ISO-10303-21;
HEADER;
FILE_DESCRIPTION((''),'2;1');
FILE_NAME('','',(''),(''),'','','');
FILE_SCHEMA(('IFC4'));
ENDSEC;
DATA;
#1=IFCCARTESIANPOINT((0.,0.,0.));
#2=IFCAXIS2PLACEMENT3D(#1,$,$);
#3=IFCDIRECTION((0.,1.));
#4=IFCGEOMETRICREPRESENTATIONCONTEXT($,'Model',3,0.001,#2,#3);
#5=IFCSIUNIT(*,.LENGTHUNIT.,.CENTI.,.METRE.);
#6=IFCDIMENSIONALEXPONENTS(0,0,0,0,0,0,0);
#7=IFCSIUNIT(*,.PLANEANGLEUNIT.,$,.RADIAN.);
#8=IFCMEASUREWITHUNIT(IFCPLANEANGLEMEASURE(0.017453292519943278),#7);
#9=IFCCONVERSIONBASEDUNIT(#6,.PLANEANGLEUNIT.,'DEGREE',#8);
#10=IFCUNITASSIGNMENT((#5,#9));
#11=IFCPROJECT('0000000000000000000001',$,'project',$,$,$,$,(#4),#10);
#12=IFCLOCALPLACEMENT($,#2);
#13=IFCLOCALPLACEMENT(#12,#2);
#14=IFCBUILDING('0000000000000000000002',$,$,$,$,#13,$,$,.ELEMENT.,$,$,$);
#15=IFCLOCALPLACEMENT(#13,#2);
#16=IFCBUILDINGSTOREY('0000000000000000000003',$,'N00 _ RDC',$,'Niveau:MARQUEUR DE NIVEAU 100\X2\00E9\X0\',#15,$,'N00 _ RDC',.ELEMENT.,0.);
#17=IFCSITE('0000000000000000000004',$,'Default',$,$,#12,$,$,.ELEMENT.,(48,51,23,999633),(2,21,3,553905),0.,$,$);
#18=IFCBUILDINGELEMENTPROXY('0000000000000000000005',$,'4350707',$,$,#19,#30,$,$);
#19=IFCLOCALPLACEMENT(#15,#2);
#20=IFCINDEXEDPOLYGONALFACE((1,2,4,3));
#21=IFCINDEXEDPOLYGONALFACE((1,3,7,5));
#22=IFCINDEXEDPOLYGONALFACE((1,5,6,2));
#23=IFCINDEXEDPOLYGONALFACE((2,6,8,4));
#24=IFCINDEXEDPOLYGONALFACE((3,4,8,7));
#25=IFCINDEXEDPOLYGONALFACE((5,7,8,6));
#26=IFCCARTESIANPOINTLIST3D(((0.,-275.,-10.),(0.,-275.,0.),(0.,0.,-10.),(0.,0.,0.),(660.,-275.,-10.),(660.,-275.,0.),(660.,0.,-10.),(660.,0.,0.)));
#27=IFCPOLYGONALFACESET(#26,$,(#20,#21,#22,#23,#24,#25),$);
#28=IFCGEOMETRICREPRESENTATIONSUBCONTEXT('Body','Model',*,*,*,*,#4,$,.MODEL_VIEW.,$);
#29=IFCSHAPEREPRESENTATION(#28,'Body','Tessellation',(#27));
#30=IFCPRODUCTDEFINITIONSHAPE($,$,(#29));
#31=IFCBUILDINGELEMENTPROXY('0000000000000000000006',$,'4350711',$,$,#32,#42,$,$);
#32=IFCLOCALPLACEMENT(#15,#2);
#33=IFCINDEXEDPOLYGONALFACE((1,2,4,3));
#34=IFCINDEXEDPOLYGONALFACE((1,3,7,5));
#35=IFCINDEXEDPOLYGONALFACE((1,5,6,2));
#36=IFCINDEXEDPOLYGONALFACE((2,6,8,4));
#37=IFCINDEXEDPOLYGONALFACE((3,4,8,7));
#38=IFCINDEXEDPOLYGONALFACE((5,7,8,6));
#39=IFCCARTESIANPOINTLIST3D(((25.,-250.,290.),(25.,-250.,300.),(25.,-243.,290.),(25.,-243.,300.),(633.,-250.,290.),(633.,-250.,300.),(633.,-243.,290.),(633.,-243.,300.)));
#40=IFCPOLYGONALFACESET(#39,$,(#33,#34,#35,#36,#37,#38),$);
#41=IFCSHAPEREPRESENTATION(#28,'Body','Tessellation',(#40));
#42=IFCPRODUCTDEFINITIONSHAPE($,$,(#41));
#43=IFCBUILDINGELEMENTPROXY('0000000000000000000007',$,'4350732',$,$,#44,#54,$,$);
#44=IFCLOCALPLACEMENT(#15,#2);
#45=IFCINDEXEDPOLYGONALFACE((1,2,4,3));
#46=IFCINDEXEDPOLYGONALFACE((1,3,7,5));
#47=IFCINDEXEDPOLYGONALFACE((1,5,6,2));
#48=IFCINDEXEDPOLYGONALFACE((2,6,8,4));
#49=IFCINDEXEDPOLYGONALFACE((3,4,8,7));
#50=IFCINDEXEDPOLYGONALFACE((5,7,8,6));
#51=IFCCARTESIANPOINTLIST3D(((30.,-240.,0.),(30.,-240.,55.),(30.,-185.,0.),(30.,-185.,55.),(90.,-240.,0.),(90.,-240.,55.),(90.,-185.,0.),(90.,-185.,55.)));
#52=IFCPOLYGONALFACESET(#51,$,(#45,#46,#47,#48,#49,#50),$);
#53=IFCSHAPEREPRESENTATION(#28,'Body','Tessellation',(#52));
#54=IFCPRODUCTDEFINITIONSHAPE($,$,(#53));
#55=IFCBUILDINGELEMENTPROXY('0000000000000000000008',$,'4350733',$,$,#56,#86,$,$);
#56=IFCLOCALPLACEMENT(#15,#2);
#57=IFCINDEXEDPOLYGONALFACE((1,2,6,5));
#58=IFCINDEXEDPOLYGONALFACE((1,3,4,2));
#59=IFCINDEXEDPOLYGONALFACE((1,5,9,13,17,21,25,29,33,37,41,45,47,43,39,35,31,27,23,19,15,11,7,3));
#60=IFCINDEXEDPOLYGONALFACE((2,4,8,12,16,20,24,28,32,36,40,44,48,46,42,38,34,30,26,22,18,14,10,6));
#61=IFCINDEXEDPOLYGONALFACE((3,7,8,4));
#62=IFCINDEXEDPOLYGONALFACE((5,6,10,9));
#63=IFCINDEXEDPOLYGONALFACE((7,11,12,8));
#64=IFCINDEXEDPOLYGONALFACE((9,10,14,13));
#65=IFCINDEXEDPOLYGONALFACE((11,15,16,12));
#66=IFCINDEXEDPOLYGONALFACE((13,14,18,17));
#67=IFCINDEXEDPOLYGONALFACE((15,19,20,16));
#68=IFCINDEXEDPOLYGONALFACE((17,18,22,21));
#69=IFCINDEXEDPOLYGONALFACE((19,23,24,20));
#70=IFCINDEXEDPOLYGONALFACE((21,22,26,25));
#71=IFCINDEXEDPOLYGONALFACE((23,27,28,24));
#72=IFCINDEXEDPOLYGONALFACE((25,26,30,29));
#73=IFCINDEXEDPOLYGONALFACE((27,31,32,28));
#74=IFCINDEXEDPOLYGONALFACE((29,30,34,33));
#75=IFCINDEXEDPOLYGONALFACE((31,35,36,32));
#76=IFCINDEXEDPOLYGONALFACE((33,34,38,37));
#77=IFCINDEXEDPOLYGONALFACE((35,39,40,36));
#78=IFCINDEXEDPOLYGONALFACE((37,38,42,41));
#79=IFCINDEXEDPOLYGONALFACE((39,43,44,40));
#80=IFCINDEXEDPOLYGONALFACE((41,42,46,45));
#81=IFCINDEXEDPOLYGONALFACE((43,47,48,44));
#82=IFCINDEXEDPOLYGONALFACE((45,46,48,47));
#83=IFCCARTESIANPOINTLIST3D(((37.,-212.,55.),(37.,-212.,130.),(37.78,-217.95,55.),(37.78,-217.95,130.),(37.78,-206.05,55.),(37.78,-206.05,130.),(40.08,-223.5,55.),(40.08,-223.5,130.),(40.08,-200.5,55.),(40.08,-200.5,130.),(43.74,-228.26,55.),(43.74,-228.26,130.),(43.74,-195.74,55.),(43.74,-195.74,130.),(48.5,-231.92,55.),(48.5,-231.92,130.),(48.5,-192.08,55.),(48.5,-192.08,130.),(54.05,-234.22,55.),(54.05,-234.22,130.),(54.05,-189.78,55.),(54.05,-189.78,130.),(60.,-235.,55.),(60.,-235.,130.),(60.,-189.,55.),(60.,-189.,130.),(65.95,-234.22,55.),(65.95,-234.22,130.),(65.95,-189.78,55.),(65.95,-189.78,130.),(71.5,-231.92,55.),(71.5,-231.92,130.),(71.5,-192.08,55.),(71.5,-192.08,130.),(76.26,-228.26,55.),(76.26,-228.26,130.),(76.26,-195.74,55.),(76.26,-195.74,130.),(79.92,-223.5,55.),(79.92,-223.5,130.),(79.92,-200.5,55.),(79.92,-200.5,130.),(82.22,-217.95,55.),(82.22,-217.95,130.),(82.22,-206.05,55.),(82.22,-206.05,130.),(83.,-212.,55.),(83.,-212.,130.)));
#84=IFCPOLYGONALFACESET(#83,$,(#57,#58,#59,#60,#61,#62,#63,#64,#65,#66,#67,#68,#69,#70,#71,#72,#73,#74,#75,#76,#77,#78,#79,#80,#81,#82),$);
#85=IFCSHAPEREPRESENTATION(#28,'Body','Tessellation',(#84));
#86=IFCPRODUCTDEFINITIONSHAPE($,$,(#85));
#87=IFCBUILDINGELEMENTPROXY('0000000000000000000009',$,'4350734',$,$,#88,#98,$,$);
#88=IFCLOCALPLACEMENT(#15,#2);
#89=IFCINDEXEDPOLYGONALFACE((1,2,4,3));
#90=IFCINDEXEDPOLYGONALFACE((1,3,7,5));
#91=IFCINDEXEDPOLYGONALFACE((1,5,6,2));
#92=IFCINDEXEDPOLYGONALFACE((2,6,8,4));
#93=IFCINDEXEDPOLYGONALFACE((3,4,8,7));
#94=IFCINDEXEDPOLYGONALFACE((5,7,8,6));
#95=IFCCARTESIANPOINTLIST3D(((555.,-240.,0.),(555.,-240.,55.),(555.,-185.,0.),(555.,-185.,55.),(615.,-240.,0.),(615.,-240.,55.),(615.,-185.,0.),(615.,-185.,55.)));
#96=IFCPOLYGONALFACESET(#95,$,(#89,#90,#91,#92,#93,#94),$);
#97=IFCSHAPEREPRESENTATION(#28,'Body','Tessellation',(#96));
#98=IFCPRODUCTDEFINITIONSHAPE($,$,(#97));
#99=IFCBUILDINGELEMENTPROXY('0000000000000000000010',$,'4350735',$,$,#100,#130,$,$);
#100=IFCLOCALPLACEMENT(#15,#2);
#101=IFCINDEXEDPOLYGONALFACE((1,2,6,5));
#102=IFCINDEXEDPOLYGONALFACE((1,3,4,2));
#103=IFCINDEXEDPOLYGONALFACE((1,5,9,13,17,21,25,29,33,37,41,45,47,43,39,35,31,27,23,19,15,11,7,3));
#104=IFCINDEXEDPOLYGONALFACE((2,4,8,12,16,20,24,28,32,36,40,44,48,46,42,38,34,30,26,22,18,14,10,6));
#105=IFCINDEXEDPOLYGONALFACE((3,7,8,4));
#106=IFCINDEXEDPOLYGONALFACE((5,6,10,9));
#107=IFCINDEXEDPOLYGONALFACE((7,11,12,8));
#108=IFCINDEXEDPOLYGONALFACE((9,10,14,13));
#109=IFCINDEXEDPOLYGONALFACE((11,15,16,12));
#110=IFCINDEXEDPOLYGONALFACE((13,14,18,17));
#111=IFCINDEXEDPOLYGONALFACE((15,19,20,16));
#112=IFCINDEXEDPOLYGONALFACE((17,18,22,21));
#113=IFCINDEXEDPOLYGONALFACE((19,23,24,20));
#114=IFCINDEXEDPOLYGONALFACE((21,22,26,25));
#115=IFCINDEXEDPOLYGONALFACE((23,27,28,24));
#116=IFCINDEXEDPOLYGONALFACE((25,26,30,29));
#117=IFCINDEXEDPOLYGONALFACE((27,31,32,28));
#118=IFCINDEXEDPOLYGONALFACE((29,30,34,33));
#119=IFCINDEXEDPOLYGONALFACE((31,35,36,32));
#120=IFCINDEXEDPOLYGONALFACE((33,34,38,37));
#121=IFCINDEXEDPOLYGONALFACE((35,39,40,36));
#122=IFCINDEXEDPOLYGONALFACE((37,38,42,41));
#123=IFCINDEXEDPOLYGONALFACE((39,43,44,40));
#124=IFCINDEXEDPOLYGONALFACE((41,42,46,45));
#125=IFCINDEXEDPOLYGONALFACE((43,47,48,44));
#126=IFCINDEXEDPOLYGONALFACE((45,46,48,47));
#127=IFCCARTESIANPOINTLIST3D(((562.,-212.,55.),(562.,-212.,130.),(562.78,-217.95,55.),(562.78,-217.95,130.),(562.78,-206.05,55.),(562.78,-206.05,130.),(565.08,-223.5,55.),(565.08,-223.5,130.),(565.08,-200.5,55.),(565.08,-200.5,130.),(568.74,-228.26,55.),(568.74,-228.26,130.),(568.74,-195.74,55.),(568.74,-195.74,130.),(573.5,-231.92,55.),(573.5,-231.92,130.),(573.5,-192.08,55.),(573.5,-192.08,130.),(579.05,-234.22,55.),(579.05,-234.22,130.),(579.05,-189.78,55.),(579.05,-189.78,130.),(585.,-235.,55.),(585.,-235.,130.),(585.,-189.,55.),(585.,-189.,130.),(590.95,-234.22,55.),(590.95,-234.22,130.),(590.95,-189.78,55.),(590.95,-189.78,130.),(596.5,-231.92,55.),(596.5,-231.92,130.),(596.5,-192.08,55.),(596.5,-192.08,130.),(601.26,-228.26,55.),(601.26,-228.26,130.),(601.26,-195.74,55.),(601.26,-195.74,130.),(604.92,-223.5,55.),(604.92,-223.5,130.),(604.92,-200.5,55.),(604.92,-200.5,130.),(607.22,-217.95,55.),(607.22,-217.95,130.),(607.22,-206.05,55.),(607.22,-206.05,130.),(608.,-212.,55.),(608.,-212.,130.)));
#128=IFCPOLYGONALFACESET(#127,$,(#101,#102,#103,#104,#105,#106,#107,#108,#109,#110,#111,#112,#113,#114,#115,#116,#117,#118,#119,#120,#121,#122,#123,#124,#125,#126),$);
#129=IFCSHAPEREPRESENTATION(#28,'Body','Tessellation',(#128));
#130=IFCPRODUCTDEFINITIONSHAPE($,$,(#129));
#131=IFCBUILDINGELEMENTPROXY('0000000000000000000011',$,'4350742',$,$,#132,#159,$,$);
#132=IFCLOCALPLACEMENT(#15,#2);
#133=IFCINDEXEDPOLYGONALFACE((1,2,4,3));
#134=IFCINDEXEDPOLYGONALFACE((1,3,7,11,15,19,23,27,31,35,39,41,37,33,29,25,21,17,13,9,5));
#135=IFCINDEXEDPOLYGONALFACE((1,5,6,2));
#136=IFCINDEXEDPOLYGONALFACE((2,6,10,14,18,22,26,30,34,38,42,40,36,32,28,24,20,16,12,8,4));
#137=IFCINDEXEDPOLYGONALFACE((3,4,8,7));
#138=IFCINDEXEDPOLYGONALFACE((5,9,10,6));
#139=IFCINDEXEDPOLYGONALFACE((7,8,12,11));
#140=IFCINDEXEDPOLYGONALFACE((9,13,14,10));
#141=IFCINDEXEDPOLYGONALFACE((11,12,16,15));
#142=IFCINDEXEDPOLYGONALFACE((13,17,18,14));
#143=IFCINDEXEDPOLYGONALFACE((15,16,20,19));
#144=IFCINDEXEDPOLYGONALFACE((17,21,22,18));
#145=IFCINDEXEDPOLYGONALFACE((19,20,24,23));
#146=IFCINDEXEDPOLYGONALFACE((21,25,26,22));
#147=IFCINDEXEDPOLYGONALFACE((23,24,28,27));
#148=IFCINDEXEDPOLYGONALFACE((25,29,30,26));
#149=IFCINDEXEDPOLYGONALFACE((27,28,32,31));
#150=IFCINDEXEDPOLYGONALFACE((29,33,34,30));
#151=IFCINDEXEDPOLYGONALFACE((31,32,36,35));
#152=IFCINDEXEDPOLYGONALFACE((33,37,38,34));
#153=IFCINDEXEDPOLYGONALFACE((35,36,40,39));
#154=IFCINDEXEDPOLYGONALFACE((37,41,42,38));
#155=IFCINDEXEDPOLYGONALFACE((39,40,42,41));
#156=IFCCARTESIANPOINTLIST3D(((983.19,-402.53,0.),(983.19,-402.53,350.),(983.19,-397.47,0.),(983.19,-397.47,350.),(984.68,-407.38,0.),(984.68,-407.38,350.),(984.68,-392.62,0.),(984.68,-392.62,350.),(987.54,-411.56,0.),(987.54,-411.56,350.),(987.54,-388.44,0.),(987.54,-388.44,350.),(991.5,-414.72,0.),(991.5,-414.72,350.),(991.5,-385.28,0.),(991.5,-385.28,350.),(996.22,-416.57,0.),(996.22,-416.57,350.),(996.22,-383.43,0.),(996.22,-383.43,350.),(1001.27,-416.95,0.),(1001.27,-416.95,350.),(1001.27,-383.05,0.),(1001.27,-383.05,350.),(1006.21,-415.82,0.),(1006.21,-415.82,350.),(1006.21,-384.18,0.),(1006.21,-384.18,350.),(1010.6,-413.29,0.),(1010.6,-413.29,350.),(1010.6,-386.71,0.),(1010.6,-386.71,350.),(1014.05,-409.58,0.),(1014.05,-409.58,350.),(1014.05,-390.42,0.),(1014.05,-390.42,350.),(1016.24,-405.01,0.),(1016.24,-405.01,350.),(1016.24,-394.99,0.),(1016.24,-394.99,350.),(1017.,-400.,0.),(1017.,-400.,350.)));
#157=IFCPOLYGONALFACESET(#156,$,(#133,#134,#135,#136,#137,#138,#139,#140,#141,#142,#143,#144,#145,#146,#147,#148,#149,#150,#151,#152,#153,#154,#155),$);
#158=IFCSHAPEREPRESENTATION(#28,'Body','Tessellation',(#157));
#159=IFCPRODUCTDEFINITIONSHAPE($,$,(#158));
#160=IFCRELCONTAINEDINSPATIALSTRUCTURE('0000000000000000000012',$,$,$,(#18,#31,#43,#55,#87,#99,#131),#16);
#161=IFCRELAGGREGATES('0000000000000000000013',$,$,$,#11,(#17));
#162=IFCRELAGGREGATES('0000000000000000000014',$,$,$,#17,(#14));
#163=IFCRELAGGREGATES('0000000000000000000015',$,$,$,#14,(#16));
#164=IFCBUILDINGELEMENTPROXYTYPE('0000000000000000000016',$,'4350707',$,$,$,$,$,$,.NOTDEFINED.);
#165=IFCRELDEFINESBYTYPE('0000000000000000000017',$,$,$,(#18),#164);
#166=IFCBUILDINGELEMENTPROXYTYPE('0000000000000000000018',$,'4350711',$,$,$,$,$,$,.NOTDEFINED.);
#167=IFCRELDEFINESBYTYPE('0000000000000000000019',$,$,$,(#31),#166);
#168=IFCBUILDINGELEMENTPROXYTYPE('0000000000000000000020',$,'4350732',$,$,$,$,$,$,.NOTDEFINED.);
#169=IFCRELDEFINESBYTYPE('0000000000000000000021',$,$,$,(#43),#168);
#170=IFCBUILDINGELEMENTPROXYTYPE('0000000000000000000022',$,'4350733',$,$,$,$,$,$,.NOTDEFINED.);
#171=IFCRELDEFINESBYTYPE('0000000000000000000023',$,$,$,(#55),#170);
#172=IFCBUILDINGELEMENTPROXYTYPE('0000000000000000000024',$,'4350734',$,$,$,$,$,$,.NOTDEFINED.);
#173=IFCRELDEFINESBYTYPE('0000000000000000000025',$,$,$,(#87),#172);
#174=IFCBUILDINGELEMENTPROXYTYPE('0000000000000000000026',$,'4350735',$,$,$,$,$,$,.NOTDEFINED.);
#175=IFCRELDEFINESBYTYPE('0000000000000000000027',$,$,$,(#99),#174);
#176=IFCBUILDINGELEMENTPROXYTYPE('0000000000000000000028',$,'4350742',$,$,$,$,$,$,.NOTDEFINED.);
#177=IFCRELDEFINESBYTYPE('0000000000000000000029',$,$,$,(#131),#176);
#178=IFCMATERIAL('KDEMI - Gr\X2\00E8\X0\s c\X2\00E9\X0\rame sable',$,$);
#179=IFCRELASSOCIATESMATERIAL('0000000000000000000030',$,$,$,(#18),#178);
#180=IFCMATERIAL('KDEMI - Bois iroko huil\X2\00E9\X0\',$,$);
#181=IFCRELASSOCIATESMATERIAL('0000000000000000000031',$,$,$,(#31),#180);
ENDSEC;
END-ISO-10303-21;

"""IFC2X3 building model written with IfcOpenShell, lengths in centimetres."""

from ifc_helpers import new_model, entity, si_unit, converted_unit, direction, frame, frame_2d, origin, origin_2d_with_axis, place, context, subcontext, project, spatial, rectangle, circle, extrude, material, type_object, element, save


model = new_model("IFC2X3")

# Units and contexts
model_context = context("Model", 3, precision=0.001, world=origin(), true_north=direction((0.0, 1.0)))
body_context = subcontext(model_context, "Body", "Model", "MODEL_VIEW")
ifc_project = project(units=[si_unit("LENGTHUNIT", "METRE", prefix="CENTI"), converted_unit("PLANEANGLEUNIT", "DEGREE", entity("IfcPlaneAngleMeasure", 0.017453292519943278), si_unit("PLANEANGLEUNIT", "RADIAN"), dimensions=[0, 0, 0, 0, 0, 0, 0])], contexts=[model_context])

# Site, building, storey
site_placement = place(None, origin())
site = spatial("IfcSite", under=ifc_project, at=site_placement, Name="Default", CompositionType="ELEMENT", RefLatitude=(48, 51, 23, 999633), RefLongitude=(2, 21, 3, 553905), RefElevation=0.0)
building_placement = place(site_placement, origin())
building = spatial("IfcBuilding", under=site, at=building_placement, CompositionType="ELEMENT")
storey_placement = place(building_placement, origin())
storey = spatial("IfcBuildingStorey", under=building, at=storey_placement, Name="N00 _ RDC", ObjectType="Niveau:MARQUEUR DE NIVEAU 100é", LongName="N00 _ RDC", CompositionType="ELEMENT", Elevation=0.0)

# Shared definitions
ifc_material_1 = material(Name="KDEMI - Bois iroko huilé")

# Building element proxies
ifc_material_2 = material(Name="KDEMI - Grès cérame sable")
building_element_proxy_type_1 = type_object("IfcBuildingElementProxyType", Name="4350707", PredefinedType="NOTDEFINED")
proxy_1_placement = place(storey_placement, origin())
element("IfcBuildingElementProxy", 1, at=proxy_1_placement, inside=storey, type_object=building_element_proxy_type_1, material=ifc_material_2, Name="4350707", context=body_context, shape_type="SweptSolid", body=[
    extrude(rectangle(XDim=660.0, YDim=275.0, at=origin_2d_with_axis()), frame((330.0, -137.5, -10.0)), (0.0, 0.0, 1.0), 10.0),
])
building_element_proxy_type_2 = type_object("IfcBuildingElementProxyType", Name="4350711", PredefinedType="NOTDEFINED")
proxy_2_placement = place(storey_placement, frame((0.0, 0.0, 25.0), z_axis=(0.0, 0.0, 1.0), x_axis=(1.0, 0.0, 0.0)))
element("IfcBuildingElementProxy", 2, at=proxy_2_placement, inside=storey, type_object=building_element_proxy_type_2, material=ifc_material_1, Name="4350711", context=body_context, shape_type="SweptSolid", body=[
    extrude(rectangle(XDim=608.0, YDim=7.0, at=frame_2d((0.0, 0.0), x_axis=(1.0, 0.0))), frame((329.0, -246.5, 265.0)), (0.0, 0.0, 1.0), 10.0),
])
building_element_proxy_type_3 = type_object("IfcBuildingElementProxyType", Name="4350732", PredefinedType="NOTDEFINED")
proxy_3_placement = place(storey_placement, origin())
element("IfcBuildingElementProxy", 3, at=proxy_3_placement, inside=storey, type_object=building_element_proxy_type_3, Name="4350732", context=body_context, shape_type="SweptSolid", body=[
    extrude(rectangle(XDim=60.0, YDim=55.0, at=frame_2d((0.0, 0.0), x_axis=(1.0, 0.0))), frame((60.0, -212.5, 0.0)), (0.0, 0.0, 1.0), 55.0),
])
building_element_proxy_type_4 = type_object("IfcBuildingElementProxyType", Name="4350733", PredefinedType="NOTDEFINED")
proxy_4_placement = place(storey_placement, origin())
element("IfcBuildingElementProxy", 4, at=proxy_4_placement, inside=storey, type_object=building_element_proxy_type_4, Name="4350733", context=body_context, shape_type="SweptSolid", body=[
    extrude(circle(Radius=23.0, at=origin_2d_with_axis()), frame((60.0, -212.0, 55.0)), (0.0, 0.0, 1.0), 75.0),
])
building_element_proxy_type_5 = type_object("IfcBuildingElementProxyType", Name="4350734", PredefinedType="NOTDEFINED")
proxy_5_placement = place(storey_placement, origin())
element("IfcBuildingElementProxy", 5, at=proxy_5_placement, inside=storey, type_object=building_element_proxy_type_5, Name="4350734", context=body_context, shape_type="SweptSolid", body=[
    extrude(rectangle(XDim=60.0, YDim=55.0, at=origin_2d_with_axis()), frame((585.0, -212.5, 0.0)), (0.0, 0.0, 1.0), 55.0),
])
building_element_proxy_type_6 = type_object("IfcBuildingElementProxyType", Name="4350735", PredefinedType="NOTDEFINED")
proxy_6_placement = place(storey_placement, origin())
element("IfcBuildingElementProxy", 6, at=proxy_6_placement, inside=storey, type_object=building_element_proxy_type_6, Name="4350735", context=body_context, shape_type="SweptSolid", body=[
    extrude(circle(Radius=23.0, at=origin_2d_with_axis()), frame((585.0, -212.0, 55.0)), (0.0, 0.0, 1.0), 75.0),
])
building_element_proxy_type_7 = type_object("IfcBuildingElementProxyType", Name="4350742", PredefinedType="NOTDEFINED")
proxy_7_placement = place(storey_placement, origin())
element("IfcBuildingElementProxy", 7, at=proxy_7_placement, inside=storey, type_object=building_element_proxy_type_7, Name="4350742", context=body_context, shape_type="SweptSolid", body=[
    extrude(circle(Radius=17.0, at=origin_2d_with_axis()), frame((1000.0, -400.0, 0.0)), (0.0, 0.0, 1.0), 350.0),
])

save(model, "model.ifc")
